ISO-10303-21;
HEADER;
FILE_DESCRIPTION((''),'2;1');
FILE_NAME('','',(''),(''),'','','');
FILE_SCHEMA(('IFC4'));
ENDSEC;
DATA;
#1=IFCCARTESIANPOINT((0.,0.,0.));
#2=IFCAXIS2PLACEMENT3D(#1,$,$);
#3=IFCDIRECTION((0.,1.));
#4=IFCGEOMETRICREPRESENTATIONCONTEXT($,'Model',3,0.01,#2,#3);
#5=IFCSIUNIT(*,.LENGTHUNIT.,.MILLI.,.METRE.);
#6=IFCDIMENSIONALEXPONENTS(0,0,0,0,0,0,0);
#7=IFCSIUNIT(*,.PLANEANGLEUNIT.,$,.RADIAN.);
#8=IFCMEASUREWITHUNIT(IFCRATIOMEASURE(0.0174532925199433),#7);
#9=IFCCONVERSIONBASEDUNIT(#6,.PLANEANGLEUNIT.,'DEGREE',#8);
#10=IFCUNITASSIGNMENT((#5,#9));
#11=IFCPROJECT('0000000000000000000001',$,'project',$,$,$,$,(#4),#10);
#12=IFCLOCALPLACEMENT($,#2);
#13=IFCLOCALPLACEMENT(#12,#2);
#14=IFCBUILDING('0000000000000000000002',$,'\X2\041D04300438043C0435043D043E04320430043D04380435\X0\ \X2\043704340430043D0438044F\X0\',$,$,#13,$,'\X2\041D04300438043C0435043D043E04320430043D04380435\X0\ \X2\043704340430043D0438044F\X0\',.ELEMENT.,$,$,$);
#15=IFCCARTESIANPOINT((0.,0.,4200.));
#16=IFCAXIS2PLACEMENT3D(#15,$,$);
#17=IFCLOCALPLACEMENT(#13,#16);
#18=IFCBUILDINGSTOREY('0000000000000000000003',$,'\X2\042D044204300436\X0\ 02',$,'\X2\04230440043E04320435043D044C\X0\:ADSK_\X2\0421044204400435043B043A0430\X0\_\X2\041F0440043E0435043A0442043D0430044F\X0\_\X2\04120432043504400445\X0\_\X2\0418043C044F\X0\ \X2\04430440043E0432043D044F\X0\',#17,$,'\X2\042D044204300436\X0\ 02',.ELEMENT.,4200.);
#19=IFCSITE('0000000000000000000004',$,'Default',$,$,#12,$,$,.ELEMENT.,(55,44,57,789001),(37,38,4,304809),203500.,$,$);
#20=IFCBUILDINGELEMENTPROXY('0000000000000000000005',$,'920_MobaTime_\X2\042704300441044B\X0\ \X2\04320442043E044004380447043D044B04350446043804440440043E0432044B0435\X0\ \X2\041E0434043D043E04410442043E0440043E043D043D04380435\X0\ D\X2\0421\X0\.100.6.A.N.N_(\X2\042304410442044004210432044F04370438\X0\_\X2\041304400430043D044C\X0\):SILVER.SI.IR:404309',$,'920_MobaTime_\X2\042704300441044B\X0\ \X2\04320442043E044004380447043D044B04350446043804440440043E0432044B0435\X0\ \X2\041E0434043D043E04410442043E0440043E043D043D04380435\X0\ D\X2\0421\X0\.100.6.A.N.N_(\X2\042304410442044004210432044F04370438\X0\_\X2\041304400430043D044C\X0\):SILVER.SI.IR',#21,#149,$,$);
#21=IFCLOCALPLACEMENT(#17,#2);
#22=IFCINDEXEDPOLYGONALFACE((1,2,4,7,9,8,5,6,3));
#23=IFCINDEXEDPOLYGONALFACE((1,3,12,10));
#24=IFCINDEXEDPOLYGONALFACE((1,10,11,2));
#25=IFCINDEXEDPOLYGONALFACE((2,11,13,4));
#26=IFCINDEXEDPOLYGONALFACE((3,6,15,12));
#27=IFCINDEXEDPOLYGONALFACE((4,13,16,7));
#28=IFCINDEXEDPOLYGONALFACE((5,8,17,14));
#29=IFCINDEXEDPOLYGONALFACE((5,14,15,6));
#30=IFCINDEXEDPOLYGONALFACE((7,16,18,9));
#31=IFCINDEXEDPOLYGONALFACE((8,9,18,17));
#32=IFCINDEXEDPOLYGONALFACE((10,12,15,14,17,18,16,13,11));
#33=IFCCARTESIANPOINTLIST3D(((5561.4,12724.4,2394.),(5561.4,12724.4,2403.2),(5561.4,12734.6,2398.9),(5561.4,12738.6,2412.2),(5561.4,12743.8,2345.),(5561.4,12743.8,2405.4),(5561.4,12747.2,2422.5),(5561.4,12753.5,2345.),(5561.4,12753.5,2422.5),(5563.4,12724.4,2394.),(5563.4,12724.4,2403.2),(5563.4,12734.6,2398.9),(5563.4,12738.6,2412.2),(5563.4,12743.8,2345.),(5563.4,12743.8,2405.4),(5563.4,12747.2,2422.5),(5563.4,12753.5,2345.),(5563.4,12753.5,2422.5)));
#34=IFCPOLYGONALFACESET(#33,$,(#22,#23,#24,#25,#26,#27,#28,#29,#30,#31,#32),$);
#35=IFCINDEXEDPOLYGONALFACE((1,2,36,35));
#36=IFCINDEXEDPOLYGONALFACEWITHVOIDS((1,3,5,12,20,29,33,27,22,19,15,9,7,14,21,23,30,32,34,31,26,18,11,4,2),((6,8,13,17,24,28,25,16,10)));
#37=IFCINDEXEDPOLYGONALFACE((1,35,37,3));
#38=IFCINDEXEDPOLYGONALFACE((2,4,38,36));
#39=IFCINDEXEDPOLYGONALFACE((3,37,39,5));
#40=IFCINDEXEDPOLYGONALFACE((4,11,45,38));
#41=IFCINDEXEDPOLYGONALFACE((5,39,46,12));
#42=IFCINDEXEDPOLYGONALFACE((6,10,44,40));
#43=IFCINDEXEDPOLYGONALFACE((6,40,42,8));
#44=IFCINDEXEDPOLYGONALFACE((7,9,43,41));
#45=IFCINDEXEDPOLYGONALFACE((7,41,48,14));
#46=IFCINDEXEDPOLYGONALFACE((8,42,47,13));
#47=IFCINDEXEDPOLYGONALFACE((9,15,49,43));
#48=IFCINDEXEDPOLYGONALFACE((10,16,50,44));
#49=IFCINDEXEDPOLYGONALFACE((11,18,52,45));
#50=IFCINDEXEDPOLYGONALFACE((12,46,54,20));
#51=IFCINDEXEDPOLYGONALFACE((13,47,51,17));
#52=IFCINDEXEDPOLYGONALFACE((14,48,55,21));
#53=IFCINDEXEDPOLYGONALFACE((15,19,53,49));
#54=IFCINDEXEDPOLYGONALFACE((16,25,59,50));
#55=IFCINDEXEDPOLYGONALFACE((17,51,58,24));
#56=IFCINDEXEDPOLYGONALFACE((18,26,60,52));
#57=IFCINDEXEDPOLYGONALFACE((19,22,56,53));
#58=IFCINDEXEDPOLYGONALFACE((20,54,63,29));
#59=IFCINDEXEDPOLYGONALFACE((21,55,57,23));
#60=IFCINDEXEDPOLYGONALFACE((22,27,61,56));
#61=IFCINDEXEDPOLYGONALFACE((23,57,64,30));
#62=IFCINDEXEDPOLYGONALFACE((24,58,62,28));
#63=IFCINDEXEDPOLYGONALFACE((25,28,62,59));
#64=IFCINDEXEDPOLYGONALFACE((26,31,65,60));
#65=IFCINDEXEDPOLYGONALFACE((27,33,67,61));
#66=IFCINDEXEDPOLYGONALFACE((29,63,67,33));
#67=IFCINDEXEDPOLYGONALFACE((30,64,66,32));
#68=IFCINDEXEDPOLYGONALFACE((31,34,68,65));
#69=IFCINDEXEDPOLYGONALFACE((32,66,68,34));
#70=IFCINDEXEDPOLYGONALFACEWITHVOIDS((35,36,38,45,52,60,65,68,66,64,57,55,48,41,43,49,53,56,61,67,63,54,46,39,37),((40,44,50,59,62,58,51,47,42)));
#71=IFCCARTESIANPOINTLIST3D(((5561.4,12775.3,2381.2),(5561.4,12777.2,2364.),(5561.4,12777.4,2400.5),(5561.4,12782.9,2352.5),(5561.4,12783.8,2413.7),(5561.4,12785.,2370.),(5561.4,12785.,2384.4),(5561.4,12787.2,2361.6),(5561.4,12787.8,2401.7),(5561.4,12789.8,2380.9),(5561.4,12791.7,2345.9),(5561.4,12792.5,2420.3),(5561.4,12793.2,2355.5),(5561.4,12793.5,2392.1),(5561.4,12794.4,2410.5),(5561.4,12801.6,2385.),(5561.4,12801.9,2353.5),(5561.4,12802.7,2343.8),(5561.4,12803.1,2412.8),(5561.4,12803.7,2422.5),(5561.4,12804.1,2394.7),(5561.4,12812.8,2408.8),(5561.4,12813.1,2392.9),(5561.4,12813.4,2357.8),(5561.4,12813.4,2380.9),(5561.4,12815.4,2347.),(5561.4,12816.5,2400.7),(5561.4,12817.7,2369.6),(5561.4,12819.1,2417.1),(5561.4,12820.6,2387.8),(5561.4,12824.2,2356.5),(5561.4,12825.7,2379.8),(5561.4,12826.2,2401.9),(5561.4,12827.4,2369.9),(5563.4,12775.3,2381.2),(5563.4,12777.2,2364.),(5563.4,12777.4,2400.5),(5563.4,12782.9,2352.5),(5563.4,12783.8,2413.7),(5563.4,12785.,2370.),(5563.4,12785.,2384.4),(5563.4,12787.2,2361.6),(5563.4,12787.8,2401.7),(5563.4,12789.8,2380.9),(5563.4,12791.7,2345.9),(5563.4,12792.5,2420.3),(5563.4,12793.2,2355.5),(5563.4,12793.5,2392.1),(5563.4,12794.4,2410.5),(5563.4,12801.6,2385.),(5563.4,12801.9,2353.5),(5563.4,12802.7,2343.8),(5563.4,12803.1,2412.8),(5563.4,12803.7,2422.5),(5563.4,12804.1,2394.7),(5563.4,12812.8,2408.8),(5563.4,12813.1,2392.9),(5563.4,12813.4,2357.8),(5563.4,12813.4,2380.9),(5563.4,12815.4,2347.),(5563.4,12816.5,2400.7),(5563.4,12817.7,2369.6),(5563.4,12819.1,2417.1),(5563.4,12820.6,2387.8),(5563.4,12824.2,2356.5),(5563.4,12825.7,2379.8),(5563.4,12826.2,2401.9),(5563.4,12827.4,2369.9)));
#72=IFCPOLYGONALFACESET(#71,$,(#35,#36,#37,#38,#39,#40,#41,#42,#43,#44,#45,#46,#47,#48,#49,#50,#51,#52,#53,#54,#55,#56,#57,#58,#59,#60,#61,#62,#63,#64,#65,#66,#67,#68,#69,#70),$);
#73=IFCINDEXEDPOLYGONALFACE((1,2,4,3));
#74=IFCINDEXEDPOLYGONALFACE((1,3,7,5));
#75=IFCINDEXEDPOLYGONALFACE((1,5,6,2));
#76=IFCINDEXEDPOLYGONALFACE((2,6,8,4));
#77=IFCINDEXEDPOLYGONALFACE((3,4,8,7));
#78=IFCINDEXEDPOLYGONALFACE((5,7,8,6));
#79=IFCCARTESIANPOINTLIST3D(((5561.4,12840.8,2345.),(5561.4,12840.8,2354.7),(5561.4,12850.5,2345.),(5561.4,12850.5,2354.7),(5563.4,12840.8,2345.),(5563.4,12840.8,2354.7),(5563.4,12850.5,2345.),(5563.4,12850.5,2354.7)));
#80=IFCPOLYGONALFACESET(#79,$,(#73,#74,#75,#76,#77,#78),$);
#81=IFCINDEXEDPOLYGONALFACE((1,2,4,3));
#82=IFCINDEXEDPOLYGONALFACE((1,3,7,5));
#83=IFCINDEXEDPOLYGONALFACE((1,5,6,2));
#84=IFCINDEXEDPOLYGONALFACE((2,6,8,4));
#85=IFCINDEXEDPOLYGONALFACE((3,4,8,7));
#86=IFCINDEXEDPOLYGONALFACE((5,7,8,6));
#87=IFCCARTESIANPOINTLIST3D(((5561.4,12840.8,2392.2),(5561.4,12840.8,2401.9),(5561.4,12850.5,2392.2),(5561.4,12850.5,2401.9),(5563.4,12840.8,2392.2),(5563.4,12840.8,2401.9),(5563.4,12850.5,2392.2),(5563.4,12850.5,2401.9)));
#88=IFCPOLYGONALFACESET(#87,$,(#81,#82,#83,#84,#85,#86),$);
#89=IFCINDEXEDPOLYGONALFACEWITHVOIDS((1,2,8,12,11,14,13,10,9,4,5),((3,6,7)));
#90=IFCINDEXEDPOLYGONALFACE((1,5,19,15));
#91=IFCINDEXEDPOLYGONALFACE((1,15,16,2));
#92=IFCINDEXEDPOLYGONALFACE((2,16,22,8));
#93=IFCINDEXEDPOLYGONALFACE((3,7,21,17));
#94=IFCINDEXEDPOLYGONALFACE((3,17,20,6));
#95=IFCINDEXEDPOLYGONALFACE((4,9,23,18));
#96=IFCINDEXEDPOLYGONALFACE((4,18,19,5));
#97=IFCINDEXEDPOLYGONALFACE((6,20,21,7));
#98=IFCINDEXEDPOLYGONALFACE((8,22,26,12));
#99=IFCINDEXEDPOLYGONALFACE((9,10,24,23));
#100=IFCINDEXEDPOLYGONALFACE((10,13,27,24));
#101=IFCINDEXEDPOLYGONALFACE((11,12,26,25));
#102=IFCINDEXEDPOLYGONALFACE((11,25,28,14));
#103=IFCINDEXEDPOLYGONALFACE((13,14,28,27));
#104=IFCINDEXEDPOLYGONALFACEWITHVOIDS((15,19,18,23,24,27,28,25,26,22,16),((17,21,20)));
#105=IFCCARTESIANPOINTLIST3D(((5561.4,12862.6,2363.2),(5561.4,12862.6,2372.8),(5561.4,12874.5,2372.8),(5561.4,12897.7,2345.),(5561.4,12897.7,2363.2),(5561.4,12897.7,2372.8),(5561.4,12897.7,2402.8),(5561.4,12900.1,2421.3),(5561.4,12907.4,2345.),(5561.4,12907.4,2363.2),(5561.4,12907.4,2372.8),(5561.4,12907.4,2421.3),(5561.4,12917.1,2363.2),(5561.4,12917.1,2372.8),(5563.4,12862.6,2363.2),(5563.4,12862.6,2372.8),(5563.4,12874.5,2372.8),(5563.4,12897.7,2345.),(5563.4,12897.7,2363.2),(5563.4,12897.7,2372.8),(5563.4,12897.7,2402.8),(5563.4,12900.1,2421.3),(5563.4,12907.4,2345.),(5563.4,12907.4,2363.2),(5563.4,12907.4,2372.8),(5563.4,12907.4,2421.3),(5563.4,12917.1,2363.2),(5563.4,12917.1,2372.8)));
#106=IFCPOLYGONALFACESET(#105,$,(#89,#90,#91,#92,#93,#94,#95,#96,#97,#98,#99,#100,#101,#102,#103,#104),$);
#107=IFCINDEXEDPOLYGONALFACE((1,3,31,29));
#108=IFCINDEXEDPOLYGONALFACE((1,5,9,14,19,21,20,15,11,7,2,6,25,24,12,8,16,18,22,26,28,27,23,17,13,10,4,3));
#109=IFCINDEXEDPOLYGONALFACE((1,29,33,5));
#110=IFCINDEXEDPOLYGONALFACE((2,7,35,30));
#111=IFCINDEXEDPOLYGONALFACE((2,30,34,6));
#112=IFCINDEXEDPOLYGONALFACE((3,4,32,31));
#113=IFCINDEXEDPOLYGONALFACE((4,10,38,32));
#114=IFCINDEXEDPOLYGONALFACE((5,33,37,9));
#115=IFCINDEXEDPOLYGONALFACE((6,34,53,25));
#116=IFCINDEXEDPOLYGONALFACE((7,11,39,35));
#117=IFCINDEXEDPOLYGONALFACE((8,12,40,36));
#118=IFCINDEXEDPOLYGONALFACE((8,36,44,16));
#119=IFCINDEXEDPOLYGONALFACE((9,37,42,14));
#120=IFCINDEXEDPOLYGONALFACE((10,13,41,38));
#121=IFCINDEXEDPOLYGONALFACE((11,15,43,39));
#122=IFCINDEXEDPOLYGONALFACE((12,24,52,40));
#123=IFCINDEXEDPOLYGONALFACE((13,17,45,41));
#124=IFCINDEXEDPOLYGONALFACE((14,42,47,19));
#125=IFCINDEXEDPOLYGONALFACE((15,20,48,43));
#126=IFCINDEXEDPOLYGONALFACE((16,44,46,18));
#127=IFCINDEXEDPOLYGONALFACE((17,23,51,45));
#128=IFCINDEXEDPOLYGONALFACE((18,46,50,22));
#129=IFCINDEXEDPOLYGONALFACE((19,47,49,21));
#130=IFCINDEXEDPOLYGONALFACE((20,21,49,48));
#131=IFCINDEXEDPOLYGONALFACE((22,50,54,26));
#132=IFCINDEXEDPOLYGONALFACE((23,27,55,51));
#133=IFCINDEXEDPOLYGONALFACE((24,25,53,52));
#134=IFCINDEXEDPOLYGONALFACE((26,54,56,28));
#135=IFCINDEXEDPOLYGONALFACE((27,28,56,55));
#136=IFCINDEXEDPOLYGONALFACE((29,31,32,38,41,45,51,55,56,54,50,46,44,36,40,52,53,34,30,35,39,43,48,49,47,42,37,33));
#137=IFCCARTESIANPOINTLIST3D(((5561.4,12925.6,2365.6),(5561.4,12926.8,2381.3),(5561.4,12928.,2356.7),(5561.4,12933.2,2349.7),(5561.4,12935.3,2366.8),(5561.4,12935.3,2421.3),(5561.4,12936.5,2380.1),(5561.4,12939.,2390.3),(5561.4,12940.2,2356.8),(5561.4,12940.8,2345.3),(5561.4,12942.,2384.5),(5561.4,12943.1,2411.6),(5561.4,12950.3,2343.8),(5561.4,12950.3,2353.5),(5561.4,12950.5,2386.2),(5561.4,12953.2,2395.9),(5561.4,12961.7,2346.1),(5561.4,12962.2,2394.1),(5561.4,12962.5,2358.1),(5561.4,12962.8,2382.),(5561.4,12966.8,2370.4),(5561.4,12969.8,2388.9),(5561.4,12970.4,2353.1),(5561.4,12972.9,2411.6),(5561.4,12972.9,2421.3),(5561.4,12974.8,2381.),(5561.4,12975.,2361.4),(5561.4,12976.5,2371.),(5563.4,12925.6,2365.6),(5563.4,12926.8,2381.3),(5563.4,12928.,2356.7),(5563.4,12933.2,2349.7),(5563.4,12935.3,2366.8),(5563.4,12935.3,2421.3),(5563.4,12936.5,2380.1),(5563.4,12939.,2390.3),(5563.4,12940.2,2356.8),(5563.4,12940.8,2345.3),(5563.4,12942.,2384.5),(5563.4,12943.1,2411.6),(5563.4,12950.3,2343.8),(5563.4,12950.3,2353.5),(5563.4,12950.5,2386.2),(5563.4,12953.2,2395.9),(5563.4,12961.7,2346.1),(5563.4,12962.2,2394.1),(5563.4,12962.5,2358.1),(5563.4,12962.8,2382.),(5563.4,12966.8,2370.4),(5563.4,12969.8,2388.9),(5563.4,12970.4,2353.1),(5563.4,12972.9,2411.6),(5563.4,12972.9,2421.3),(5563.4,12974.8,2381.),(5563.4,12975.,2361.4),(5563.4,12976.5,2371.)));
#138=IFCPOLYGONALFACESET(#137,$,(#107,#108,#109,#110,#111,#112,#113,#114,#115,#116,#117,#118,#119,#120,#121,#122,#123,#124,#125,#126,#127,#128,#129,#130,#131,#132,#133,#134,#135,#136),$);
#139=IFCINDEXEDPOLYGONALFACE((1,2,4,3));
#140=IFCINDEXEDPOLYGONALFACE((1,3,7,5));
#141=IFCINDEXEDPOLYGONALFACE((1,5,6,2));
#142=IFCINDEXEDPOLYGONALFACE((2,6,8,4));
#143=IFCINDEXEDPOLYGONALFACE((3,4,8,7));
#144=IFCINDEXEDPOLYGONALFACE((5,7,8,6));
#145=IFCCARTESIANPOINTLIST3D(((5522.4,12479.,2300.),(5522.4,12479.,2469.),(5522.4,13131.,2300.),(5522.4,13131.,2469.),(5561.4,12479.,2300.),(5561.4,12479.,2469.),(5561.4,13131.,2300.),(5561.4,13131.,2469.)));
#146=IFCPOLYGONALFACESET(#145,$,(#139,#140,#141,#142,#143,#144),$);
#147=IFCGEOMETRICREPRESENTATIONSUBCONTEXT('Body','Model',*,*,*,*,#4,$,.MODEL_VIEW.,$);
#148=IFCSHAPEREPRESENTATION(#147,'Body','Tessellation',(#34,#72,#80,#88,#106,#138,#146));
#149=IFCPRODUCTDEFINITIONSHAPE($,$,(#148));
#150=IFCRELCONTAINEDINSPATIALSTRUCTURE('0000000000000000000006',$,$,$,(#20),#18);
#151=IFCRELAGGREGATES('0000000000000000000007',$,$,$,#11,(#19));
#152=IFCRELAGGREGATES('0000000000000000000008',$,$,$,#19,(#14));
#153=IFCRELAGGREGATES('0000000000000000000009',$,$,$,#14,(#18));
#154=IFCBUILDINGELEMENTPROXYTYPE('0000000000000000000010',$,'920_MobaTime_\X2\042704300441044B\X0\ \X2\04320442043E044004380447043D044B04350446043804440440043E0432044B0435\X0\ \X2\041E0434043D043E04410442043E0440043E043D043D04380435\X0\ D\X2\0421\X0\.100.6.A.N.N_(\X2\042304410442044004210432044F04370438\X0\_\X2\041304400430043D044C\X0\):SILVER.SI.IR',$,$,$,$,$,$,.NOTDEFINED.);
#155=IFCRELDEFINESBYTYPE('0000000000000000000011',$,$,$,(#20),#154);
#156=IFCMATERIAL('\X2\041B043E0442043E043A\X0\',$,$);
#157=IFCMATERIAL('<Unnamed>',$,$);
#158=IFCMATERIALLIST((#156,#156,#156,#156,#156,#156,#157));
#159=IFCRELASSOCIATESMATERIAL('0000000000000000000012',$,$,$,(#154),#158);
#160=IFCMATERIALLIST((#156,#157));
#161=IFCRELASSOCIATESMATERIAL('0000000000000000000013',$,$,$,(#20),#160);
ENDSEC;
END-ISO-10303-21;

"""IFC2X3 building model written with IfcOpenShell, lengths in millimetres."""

from ifc_helpers import new_model, entity, si_unit, converted_unit, direction, frame, origin, origin_2d_with_axis, place, context, subcontext, project, spatial, polyline, rectangle, outline, extrude, source, transform, mapped, material, material_list, type_object, type_shapes, element, save


model = new_model("IFC2X3")

# Units and contexts
model_context = context("Model", 3, precision=0.01, world=origin(), true_north=direction((0.0, 1.0)))
body_context = subcontext(model_context, "Body", "Model", "MODEL_VIEW")
ifc_project = project(units=[si_unit("LENGTHUNIT", "METRE", prefix="MILLI"), converted_unit("PLANEANGLEUNIT", "DEGREE", entity("IfcRatioMeasure", 0.0174532925199433), si_unit("PLANEANGLEUNIT", "RADIAN"), dimensions=[0, 0, 0, 0, 0, 0, 0])], contexts=[model_context])

# Site, building, storey
site_placement = place(None, frame((0.0, 0.0, 0.0)))
site = spatial("IfcSite", under=ifc_project, at=site_placement, Name="Default", CompositionType="ELEMENT", RefLatitude=(55, 44, 57, 789001), RefLongitude=(37, 38, 4, 304809), RefElevation=203500.0)
building_placement = place(site_placement, origin())
building = spatial("IfcBuilding", under=site, at=building_placement, Name="Наименование здания", LongName="Наименование здания", CompositionType="ELEMENT")
storey_placement = place(building_placement, frame((0.0, 0.0, 4200.0)))
storey = spatial("IfcBuildingStorey", under=building, at=storey_placement, Name="Этаж 02", ObjectType="Уровень:ADSK_Стрелка_Проектная_Вверх_Имя уровня", LongName="Этаж 02", CompositionType="ELEMENT", Elevation=4200.0)

# Building element proxy
ifc_material_1 = material(Name="Лоток")
ifc_material_2 = material(Name="<Unnamed>")
ifc_material_list_1 = material_list([ifc_material_1, ifc_material_1, ifc_material_1, ifc_material_1, ifc_material_1, ifc_material_1, ifc_material_2])
building_element_proxy_type_1 = type_object("IfcBuildingElementProxyType", Name="920_MobaTime_Часы вторичныецифровые Односторонние DС.100.6.A.N.N_(УстрСвязи_Грань):SILVER.SI.IR", PredefinedType="NOTDEFINED", material=ifc_material_list_1)
shared_shape_1 = source(origin(), body_context, "Body", "SweptSolid", [
    extrude(outline(polyline([(-49.3, -13.1), (28.2, -13.1), (28.2, -6.8), (17.9, 1.8), (8.9, 16.0), (-0.3, 16.0), (4.6, 5.8), (11.1, -3.4), (-49.3, -3.4), (-49.3, -13.1)])), frame((-64.6, 9.8, 39.0), z_axis=(0.0, 0.0, 1.0), x_axis=(0.0, 1.0, 0.0)), (0.0, 0.0, 1.0), 2.0),
    extrude(outline(polyline([(2.2, -27.6), (19.0, -27.6), (30.5, -16.1), (33.3, -4.9), (31.0, 5.8), (21.8, 17.2), (5.2, 27.3), (-11.1, 33.0), (-24.0, 32.7), (-33.6, 27.6), (-40.3, 18.6), (-42.8, 5.7), (-38.0, -6.3), (-27.2, -15.0), (-17.5, -17.7), (-8.2, -16.4), (-0.3, -11.9), (5.1, -4.5), (7.3, 6.2), (4.0, 17.2), (18.5, 7.3), (23.6, -2.4), (22.0, -11.4), (14.2, -18.4), (5.3, -18.3), (2.2, -27.6)]), holes=[polyline([(-9.0, 23.3), (-1.3, 14.4), (-2.6, 2.0), (-11.4, -7.0), (-23.4, -6.1), (-32.2, 2.9), (-31.2, 15.1), (-25.6, 22.1), (-17.5, 24.9), (-9.0, 23.3)])]), frame((-2.7, 3.6, 39.0), z_axis=(0.0, 0.0, 1.0), x_axis=(-0.427649, 0.903945, 0.0)), (0.0, 0.0, 1.0), 2.0),
    extrude(rectangle(XDim=9.7, YDim=9.7, at=origin_2d_with_axis()), frame((40.6, -34.7, 39.0)), (0.0, 0.0, 1.0), 2.0),
    extrude(rectangle(XDim=9.7, YDim=9.7, at=origin_2d_with_axis()), frame((40.6, 12.6, 39.0)), (0.0, 0.0, 1.0), 2.0),
    extrude(outline(polyline([(-0.9, -28.1), (8.8, -28.1), (8.8, -9.9), (18.5, -9.9), (18.5, -0.2), (8.8, -0.2), (8.8, 48.3), (1.5, 48.3), (-36.0, -0.2), (-36.0, -9.9), (-0.9, -9.9), (-0.9, -28.1)]), holes=[polyline([(-0.9, -0.2), (-24.1, -0.2), (-0.9, 29.7), (-0.9, -0.2)])]), frame((93.6, -11.4, 39.0)), (0.0, 0.0, 1.0), 2.0),
    extrude(outline(polyline([(3.3, -28.3), (12.5, -28.3), (20.5, -25.0), (26.8, -18.8), (30.7, -10.0), (31.4, 1.6), (26.9, 11.8), (20.1, 18.4), (11.1, 22.3), (1.0, 23.3), (-7.9, 20.4), (-14.9, 14.5), (-18.9, 6.2), (-17.1, -9.0), (-36.7, 0.5), (-29.1, 29.3), (-38.5, 31.7), (-48.1, -4.6), (-11.6, -23.0), (-8.0, -14.0), (-10.8, -7.6), (-10.2, 1.1), (-3.0, 11.8), (9.2, 12.8), (20.0, 5.4), (21.3, -7.5), (15.5, -16.4), (4.6, -18.6), (3.3, -28.3)])), frame((147.1, -8.5, 39.0), z_axis=(0.0, 0.0, 1.0), x_axis=(0.256974, -0.966418, 0.0)), (0.0, 0.0, 1.0), 2.0),
    extrude(rectangle(XDim=652.0, YDim=169.0, at=origin_2d_with_axis()), frame((0.0, 0.0, 0.0), z_axis=(0.0, 0.0, 1.0), x_axis=(-1.0, 0.0, 0.0)), (0.0, 0.0, 1.0), 39.0),
])
type_shapes(building_element_proxy_type_1, [shared_shape_1])
ifc_material_list_2 = material_list([ifc_material_1, ifc_material_2])
proxy_1_placement = place(storey_placement, frame((5522.4, 12805.0, 2384.5), z_axis=(1.0, 0.0, 0.0), x_axis=(0.0, 1.0, 0.0)))
element("IfcBuildingElementProxy", 1, at=proxy_1_placement, inside=storey, type_object=building_element_proxy_type_1, material=ifc_material_list_2, Name="920_MobaTime_Часы вторичныецифровые Односторонние DС.100.6.A.N.N_(УстрСвязи_Грань):SILVER.SI.IR:404309", ObjectType="920_MobaTime_Часы вторичныецифровые Односторонние DС.100.6.A.N.N_(УстрСвязи_Грань):SILVER.SI.IR", context=body_context, shape_type="MappedRepresentation", body=[
    mapped(shared_shape_1, transform((0.0, 0.0, 0.0), scale=1.0)),
])

save(model, "model.ifc")
